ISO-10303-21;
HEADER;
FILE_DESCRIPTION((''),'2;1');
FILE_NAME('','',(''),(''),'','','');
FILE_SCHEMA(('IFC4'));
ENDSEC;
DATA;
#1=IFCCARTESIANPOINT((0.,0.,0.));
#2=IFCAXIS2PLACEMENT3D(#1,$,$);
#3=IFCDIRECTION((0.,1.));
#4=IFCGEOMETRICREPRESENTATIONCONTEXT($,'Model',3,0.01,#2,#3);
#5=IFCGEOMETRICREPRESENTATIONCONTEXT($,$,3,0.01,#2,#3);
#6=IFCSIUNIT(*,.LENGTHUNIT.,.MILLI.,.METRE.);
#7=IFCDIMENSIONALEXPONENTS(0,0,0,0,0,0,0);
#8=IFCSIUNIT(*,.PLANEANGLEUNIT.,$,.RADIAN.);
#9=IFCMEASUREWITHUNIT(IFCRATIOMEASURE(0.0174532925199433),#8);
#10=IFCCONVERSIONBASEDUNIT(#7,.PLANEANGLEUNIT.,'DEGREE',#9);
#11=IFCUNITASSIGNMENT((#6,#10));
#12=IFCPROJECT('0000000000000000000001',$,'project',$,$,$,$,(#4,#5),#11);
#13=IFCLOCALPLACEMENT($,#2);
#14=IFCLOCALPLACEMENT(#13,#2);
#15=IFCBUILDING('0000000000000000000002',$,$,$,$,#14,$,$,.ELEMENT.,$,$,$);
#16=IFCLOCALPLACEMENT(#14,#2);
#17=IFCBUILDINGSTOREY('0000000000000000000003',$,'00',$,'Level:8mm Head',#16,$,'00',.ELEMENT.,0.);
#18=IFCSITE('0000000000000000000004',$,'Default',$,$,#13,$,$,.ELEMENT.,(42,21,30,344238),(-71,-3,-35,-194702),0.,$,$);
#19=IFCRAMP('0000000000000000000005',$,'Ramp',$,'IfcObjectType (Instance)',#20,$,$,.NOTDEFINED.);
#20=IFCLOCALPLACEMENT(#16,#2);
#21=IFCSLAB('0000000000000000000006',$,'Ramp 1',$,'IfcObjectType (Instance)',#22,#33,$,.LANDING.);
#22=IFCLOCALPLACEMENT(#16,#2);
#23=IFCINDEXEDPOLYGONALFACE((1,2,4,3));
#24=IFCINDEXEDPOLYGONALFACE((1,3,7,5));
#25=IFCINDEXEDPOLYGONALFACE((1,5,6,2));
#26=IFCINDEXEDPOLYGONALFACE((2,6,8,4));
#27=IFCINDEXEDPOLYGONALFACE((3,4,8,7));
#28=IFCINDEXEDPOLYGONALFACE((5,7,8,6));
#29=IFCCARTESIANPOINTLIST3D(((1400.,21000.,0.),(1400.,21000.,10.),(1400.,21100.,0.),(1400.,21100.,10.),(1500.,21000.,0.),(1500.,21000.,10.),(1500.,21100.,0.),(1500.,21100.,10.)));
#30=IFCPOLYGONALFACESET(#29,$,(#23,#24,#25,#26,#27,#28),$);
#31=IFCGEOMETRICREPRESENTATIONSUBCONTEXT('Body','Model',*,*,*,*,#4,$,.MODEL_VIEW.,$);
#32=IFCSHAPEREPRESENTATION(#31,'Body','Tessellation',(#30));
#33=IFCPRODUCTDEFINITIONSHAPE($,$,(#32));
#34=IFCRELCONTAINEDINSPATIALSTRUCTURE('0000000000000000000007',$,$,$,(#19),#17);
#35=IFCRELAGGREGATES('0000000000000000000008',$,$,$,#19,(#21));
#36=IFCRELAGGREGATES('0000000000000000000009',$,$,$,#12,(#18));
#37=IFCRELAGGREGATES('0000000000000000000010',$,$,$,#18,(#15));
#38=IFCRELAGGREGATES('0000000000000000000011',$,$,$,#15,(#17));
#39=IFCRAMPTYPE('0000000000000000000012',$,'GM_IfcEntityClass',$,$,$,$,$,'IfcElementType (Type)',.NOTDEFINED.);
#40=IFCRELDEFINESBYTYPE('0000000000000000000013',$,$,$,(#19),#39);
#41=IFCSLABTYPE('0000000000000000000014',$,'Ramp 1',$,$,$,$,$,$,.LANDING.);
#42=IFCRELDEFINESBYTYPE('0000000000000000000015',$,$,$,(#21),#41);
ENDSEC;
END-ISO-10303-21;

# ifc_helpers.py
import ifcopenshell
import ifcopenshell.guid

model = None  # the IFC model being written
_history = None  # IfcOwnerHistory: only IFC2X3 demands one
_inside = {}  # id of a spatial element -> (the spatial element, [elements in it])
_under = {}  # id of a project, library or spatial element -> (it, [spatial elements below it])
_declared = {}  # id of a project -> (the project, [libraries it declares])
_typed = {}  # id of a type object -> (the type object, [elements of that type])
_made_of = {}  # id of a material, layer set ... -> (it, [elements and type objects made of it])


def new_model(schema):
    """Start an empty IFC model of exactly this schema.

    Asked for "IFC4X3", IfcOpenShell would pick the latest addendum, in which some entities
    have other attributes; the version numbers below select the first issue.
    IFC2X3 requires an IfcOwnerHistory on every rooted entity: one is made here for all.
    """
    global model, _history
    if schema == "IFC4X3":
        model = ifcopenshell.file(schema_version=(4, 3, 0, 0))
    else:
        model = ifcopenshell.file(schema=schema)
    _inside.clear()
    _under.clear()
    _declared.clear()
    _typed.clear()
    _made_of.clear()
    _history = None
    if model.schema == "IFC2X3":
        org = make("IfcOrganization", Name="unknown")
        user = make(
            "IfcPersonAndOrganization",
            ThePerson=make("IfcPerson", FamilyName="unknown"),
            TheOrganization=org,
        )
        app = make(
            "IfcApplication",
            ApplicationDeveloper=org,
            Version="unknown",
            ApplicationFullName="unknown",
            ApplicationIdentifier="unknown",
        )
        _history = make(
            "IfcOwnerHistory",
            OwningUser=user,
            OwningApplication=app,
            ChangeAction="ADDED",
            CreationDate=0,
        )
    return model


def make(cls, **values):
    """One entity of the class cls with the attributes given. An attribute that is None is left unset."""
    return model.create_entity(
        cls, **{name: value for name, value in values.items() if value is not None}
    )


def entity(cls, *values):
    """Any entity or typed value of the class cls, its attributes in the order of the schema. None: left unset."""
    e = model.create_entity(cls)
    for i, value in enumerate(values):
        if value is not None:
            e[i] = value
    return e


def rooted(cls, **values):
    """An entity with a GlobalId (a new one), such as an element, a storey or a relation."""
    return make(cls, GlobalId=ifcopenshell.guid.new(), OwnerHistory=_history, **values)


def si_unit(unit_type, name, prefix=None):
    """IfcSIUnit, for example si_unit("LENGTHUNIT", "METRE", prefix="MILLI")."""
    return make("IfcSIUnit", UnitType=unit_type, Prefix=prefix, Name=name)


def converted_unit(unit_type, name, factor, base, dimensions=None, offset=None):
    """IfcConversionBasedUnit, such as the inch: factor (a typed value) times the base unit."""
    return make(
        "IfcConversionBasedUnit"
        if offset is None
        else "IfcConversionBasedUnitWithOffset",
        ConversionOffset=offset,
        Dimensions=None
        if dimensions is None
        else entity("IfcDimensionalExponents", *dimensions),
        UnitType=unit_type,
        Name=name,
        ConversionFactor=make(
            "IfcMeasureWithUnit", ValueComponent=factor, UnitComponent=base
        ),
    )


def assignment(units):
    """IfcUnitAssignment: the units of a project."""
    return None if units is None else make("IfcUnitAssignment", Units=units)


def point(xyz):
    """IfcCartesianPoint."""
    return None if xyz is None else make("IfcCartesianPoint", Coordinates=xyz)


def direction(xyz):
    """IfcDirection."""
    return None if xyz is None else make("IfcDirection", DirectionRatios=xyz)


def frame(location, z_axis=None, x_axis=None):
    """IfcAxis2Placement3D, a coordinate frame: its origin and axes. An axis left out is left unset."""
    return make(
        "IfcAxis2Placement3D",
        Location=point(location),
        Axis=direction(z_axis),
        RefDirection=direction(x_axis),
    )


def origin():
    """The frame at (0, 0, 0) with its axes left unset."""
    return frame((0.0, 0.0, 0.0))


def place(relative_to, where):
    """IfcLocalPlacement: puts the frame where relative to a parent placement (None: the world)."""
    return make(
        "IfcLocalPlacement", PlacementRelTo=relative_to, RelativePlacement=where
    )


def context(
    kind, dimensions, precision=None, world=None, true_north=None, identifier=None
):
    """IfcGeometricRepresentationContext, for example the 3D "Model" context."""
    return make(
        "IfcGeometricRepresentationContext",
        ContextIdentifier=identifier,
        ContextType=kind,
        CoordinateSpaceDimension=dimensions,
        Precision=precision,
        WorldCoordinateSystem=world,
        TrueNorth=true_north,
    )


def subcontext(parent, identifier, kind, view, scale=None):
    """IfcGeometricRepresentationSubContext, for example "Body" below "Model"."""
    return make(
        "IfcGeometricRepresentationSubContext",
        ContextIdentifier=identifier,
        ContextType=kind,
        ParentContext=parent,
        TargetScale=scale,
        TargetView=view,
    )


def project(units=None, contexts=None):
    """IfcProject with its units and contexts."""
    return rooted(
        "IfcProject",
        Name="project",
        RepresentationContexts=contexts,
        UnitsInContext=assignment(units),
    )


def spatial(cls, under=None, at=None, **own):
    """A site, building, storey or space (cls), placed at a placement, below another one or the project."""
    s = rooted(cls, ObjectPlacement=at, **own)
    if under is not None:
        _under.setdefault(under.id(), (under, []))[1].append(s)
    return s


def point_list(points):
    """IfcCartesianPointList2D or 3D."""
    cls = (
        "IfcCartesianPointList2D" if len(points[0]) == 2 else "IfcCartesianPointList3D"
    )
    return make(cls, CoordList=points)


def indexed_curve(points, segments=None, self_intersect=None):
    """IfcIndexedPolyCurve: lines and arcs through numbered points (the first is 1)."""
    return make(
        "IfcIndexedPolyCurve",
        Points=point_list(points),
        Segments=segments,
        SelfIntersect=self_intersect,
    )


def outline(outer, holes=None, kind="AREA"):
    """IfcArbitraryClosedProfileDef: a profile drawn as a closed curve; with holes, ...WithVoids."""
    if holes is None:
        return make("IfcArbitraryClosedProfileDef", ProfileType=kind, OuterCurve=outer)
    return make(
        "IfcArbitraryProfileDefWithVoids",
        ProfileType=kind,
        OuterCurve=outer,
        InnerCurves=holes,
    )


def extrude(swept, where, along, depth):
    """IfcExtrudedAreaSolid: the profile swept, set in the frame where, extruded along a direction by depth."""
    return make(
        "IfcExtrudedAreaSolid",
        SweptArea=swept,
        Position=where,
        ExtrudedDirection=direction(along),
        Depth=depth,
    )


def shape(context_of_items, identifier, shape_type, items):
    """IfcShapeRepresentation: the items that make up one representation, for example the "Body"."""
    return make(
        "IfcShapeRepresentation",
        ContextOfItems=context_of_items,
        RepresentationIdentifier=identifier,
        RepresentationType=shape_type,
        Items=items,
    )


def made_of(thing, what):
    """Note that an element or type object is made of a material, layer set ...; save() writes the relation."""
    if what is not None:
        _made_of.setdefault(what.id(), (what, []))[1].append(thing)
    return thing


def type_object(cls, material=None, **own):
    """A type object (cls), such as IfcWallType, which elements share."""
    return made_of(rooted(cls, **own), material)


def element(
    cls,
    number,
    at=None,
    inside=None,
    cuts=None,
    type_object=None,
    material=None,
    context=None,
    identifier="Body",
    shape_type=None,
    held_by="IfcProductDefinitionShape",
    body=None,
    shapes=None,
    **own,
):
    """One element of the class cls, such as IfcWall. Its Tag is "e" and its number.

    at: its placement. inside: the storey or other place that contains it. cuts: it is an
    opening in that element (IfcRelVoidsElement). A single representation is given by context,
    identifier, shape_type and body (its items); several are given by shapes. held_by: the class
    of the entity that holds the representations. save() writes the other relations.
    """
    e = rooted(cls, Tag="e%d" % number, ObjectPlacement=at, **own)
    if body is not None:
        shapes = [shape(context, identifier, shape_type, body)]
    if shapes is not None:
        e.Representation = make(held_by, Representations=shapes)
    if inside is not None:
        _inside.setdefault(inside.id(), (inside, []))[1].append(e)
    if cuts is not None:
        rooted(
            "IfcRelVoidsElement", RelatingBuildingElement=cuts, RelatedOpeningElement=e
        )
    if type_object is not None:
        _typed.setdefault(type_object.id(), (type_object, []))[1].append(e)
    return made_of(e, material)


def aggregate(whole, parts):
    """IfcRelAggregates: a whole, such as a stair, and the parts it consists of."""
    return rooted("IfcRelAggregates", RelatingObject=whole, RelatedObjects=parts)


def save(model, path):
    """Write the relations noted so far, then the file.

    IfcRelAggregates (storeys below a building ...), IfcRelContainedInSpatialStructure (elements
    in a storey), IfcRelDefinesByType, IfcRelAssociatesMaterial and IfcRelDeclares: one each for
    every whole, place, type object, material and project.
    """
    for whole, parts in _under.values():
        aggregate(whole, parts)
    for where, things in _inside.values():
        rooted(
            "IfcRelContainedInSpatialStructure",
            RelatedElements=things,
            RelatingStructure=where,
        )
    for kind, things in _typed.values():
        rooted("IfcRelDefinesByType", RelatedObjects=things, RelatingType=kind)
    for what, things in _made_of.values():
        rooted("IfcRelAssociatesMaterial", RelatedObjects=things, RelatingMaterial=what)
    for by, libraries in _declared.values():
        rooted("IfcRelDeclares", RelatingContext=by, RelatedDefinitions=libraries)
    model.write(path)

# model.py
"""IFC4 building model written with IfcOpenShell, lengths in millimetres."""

from ifc_helpers import new_model, entity, si_unit, converted_unit, direction, frame, origin, place, context, subcontext, project, spatial, indexed_curve, outline, extrude, type_object, element, aggregate, save


model = new_model("IFC4")

# Units and contexts
model_context = context("Model", 3, precision=0.01, world=origin(), true_north=direction((0.0, 1.0)))
context_of_model = context(None, 3, precision=0.01, world=origin(), true_north=direction((0.0, 1.0)))
body_context = subcontext(model_context, "Body", "Model", "MODEL_VIEW")
ifc_project = project(units=[si_unit("LENGTHUNIT", "METRE", prefix="MILLI"), converted_unit("PLANEANGLEUNIT", "DEGREE", entity("IfcRatioMeasure", 0.0174532925199433), si_unit("PLANEANGLEUNIT", "RADIAN"), dimensions=[0, 0, 0, 0, 0, 0, 0])], contexts=[model_context, context_of_model])

# Site, building, storey
site_placement = place(None, origin())
site = spatial("IfcSite", under=ifc_project, at=site_placement, Name="Default", CompositionType="ELEMENT", RefLatitude=(42, 21, 30, 344238), RefLongitude=(-71, -3, -35, -194702), RefElevation=0.0)
building_placement = place(site_placement, origin())
building = spatial("IfcBuilding", under=site, at=building_placement, CompositionType="ELEMENT")
storey_placement = place(building_placement, origin())
storey = spatial("IfcBuildingStorey", under=building, at=storey_placement, Name="00", ObjectType="Level:8mm Head", LongName="00", CompositionType="ELEMENT", Elevation=0.0)

# Ramp, slab
ramp_type = type_object("IfcRampType", Name="GM_IfcEntityClass", ElementType="IfcElementType (Type)", PredefinedType="NOTDEFINED")
ramp_placement = place(storey_placement, origin())
ramp = element("IfcRamp", 1, at=ramp_placement, inside=storey, type_object=ramp_type, Name="Ramp", ObjectType="IfcObjectType (Instance)", PredefinedType="NOTDEFINED")
slab_type = type_object("IfcSlabType", Name="Ramp 1", PredefinedType="LANDING")
slab_placement = place(ramp_placement, origin())
slab = element("IfcSlab", 2, at=slab_placement, type_object=slab_type, Name="Ramp 1", ObjectType="IfcObjectType (Instance)", PredefinedType="LANDING", context=body_context, shape_type="SweptSolid", body=[
    extrude(outline(indexed_curve([(-50.0, -50.0), (50.0, -50.0), (50.0, 50.0), (-50.0, 50.0), (-50.0, -50.0)], self_intersect=False)), frame((1450.0, 21050.0, 0.0), z_axis=(0.0, 0.0, 1.0), x_axis=(0.0, 1.0, 0.0)), (0.0, 0.0, 1.0), 10.0),
])
aggregate(ramp, [slab])

save(model, "model.ifc")
